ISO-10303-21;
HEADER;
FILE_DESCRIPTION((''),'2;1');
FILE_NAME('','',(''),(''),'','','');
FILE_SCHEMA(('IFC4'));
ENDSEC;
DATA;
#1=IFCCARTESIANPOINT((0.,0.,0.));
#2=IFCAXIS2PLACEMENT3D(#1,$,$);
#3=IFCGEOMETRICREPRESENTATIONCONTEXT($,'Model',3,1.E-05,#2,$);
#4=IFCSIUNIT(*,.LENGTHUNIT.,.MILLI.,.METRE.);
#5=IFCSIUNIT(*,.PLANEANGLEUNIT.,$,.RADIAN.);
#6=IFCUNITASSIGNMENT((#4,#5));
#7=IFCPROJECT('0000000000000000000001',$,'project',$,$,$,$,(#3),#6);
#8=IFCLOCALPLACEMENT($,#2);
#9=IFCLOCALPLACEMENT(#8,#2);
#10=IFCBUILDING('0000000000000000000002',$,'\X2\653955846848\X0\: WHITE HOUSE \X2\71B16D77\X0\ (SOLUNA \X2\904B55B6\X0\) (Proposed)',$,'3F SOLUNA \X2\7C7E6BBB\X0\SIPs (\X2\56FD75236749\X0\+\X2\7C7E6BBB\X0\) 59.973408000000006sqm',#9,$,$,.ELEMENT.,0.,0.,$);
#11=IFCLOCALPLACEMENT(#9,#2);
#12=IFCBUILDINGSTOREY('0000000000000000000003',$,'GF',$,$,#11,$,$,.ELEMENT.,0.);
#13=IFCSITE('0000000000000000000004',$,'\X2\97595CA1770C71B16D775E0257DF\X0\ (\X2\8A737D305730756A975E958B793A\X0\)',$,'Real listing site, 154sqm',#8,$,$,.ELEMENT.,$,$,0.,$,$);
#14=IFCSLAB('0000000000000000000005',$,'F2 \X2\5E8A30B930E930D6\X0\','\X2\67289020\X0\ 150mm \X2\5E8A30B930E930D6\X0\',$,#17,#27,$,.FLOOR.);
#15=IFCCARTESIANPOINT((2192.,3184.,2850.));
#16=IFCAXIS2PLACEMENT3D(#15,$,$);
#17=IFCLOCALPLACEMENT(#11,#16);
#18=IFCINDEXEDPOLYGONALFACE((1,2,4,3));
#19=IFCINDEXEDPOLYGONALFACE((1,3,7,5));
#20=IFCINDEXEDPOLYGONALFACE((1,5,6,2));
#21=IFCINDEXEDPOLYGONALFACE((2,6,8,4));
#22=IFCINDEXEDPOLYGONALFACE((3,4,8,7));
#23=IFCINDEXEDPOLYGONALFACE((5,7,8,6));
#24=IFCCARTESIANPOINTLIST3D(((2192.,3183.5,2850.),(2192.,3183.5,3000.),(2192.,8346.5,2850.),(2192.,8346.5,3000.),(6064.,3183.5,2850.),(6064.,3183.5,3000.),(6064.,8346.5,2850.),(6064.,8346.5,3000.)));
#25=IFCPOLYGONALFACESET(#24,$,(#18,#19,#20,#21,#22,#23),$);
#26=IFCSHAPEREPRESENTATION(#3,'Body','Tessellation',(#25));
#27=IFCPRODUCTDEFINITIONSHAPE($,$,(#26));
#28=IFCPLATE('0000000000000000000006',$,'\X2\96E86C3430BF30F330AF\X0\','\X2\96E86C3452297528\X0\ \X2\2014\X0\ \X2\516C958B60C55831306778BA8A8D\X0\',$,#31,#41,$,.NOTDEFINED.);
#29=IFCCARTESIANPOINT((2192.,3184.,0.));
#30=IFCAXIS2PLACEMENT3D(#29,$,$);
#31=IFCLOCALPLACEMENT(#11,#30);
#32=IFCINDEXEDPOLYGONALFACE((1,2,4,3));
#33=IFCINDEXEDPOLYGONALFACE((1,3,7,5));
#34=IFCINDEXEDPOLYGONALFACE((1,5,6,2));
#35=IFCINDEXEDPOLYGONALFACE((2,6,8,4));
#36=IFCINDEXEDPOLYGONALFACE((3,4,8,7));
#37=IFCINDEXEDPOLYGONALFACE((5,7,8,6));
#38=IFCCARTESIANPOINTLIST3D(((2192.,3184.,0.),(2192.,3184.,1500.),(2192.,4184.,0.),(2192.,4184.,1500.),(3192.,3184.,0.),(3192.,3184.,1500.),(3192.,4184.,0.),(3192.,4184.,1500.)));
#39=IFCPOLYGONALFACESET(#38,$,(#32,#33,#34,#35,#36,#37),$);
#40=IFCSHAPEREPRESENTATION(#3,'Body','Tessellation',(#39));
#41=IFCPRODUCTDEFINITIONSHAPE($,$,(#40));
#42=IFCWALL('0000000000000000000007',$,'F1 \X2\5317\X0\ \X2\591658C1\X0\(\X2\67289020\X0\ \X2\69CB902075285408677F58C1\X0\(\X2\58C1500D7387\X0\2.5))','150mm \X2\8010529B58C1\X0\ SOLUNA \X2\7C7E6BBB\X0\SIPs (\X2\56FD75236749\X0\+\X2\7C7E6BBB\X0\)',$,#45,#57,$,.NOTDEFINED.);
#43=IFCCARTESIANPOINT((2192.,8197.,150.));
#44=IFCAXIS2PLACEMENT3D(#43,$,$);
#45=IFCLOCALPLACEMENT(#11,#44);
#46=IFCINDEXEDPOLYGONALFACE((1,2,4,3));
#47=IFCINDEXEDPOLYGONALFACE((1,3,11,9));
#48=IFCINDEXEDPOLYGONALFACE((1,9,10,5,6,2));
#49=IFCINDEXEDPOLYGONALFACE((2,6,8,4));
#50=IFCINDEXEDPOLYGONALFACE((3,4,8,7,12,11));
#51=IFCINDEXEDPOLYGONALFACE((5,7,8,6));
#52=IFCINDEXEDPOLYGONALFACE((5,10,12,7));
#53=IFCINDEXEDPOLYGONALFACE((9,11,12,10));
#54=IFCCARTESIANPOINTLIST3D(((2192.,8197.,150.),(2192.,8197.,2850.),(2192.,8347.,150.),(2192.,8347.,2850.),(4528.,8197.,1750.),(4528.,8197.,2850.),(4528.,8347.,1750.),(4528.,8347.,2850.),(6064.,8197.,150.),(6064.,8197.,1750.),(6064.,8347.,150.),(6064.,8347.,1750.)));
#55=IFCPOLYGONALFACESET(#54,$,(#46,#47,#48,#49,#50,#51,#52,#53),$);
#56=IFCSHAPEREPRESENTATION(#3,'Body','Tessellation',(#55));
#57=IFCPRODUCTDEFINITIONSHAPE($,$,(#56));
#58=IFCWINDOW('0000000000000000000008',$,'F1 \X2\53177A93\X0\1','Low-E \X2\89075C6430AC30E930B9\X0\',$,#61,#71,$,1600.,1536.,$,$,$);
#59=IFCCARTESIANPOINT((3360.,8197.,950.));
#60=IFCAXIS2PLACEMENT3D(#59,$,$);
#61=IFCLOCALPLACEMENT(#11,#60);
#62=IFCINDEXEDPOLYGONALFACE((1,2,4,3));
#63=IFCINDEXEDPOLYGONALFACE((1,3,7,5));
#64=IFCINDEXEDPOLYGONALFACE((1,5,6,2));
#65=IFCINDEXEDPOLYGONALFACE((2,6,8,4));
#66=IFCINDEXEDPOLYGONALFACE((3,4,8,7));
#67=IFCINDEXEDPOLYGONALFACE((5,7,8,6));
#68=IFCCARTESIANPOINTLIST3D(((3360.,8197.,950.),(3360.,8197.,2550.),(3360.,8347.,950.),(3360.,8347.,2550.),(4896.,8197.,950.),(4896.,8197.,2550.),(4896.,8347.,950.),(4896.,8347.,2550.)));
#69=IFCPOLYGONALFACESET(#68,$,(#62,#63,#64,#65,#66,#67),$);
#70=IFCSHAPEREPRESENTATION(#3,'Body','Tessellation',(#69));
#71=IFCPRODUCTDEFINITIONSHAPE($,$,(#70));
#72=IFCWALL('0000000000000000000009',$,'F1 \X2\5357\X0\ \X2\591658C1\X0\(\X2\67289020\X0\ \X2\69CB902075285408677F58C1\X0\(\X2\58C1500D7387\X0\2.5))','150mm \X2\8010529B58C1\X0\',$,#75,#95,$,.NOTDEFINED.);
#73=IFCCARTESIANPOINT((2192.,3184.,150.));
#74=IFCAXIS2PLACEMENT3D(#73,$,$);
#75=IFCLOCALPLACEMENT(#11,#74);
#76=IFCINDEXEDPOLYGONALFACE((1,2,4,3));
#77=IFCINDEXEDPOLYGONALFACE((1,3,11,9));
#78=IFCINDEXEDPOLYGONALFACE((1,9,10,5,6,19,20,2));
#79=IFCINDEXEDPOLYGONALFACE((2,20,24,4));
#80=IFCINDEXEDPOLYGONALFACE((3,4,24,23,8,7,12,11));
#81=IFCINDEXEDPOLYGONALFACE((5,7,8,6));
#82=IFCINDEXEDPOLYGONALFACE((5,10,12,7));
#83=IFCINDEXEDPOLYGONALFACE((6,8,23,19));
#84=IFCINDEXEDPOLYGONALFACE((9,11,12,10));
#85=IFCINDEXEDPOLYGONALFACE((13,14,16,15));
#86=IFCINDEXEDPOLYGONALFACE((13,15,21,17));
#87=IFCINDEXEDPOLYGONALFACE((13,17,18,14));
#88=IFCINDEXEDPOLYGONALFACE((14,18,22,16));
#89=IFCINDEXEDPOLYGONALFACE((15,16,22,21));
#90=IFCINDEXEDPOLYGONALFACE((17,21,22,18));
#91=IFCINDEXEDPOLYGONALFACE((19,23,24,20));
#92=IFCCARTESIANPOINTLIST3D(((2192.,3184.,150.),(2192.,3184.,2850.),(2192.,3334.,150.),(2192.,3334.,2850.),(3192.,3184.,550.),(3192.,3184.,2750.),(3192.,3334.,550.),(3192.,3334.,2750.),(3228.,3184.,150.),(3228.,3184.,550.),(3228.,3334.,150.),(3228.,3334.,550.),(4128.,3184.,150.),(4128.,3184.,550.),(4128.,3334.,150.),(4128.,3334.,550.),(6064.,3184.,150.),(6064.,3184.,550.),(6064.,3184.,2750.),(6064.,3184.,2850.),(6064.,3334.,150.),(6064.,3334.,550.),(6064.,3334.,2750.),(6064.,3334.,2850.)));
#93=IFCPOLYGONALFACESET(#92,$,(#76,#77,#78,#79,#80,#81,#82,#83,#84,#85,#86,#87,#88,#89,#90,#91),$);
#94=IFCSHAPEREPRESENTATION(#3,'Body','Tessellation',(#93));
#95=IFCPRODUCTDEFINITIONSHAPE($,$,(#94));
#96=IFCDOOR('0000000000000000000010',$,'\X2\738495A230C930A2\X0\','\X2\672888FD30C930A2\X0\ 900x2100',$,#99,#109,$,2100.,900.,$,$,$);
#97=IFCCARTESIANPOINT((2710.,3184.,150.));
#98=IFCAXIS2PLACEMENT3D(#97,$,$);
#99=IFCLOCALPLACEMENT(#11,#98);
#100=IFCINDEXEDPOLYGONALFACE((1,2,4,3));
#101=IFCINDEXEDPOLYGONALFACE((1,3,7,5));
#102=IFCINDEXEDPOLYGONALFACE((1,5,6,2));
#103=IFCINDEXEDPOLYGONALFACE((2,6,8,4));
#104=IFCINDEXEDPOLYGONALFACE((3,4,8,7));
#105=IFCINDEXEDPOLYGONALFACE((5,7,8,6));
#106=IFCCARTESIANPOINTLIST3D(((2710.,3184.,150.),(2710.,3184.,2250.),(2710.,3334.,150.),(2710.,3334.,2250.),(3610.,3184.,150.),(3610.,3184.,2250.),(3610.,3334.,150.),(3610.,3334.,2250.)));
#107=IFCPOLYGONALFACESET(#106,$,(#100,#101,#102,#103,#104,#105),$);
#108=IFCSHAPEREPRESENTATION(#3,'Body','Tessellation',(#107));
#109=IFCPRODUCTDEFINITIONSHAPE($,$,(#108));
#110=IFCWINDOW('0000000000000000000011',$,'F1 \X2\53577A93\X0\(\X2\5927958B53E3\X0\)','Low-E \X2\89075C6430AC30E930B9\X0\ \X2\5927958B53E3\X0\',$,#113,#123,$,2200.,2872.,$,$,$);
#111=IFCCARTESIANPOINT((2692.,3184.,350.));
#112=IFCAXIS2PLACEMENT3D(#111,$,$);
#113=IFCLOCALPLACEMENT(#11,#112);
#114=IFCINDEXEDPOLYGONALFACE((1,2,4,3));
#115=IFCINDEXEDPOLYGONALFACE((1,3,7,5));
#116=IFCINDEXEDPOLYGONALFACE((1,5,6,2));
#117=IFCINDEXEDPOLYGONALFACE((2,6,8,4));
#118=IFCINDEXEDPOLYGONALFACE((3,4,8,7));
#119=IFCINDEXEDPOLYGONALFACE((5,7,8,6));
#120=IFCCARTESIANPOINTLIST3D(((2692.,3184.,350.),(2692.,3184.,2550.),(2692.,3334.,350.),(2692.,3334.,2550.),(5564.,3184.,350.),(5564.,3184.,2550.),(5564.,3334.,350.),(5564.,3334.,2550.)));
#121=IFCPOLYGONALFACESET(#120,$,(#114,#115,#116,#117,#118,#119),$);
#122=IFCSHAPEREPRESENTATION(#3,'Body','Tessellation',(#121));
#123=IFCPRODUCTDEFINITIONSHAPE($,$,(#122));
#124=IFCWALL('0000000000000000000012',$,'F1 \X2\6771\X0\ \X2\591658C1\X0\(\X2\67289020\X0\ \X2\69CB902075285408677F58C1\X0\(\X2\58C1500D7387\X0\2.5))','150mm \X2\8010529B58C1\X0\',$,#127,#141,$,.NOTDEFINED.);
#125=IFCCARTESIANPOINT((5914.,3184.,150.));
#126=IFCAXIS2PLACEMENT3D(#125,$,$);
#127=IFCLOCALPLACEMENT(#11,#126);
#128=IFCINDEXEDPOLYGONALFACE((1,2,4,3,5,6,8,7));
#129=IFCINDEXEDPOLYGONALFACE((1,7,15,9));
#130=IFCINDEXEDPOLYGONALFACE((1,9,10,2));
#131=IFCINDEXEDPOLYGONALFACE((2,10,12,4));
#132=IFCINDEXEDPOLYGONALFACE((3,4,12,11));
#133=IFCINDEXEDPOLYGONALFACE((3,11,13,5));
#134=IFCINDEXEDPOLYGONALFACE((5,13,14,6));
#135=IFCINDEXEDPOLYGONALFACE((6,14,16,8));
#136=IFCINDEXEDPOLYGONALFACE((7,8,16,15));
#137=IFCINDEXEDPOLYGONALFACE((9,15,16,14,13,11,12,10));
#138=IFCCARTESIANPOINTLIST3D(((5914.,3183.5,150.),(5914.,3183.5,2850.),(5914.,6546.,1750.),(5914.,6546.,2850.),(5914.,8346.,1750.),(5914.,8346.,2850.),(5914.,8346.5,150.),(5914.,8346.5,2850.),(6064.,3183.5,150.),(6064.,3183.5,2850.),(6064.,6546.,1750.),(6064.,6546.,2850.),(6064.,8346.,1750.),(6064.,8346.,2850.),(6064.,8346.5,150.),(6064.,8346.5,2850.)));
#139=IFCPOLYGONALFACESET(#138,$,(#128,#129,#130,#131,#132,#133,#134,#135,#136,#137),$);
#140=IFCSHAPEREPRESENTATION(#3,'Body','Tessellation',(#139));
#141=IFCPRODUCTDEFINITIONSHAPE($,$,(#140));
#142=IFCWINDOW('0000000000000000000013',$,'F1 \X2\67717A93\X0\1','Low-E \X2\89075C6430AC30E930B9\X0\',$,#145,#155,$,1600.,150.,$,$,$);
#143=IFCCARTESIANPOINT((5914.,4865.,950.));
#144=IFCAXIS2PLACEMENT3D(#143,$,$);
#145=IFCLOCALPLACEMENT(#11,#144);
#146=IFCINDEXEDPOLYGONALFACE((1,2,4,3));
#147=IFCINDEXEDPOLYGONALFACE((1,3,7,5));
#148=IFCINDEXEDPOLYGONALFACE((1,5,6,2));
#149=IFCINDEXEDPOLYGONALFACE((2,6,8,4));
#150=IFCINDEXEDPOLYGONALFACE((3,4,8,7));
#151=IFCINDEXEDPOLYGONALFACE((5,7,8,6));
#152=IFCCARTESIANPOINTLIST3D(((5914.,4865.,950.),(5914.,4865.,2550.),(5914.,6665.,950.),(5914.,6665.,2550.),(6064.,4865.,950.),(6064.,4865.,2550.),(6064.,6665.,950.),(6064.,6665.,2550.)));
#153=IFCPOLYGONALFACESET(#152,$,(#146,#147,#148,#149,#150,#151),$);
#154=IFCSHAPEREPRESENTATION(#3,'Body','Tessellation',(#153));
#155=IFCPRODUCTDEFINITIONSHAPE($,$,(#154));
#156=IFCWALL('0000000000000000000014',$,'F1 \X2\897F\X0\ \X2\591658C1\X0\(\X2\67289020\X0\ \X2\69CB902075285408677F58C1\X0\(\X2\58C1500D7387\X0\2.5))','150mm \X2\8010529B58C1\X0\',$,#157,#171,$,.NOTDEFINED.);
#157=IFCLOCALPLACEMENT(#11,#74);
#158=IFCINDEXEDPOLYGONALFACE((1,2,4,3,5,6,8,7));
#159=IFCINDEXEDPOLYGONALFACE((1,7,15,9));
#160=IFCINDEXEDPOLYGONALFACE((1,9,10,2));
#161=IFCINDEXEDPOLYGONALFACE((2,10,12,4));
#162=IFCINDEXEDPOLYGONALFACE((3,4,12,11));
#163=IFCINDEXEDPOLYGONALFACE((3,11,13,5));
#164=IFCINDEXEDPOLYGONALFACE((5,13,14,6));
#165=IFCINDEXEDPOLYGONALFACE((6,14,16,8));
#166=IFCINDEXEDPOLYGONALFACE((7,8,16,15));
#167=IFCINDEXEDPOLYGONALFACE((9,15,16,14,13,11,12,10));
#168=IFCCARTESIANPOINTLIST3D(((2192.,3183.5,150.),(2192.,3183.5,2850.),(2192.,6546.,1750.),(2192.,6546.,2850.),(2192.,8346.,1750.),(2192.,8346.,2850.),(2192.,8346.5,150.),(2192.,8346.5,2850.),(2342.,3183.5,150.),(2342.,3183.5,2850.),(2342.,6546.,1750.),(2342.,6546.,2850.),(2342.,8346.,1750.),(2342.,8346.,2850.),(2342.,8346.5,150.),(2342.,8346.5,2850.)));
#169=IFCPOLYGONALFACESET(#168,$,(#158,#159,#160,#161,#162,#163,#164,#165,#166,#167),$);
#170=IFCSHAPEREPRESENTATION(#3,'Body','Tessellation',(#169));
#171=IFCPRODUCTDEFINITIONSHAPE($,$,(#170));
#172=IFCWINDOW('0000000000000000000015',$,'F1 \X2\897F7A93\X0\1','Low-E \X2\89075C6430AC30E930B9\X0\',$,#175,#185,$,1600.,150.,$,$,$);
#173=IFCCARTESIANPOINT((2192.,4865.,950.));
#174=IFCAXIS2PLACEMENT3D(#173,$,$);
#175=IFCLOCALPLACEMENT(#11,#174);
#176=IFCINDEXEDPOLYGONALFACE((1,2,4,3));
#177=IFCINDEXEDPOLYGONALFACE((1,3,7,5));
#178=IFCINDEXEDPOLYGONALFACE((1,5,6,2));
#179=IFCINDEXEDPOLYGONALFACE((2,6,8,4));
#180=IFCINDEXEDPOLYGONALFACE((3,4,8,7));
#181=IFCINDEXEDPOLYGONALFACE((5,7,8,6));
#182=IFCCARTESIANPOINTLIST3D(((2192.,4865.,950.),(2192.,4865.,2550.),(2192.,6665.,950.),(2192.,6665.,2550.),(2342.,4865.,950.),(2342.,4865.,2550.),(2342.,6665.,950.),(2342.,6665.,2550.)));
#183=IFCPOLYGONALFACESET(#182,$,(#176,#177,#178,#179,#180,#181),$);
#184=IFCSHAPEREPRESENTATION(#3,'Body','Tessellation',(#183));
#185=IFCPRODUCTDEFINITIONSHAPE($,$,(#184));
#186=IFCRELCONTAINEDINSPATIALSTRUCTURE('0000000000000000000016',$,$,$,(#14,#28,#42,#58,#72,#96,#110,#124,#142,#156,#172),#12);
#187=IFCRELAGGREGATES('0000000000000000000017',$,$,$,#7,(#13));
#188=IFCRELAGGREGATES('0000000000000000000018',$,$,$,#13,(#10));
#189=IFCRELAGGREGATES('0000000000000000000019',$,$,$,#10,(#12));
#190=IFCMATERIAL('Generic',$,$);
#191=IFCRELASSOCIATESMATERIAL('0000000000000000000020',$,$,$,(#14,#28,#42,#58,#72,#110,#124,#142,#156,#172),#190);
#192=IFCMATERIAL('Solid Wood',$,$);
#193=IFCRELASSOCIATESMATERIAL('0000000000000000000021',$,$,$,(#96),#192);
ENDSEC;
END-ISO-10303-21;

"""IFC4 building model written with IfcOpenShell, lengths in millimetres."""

from ifc_helpers import new_model, si_unit, frame, frame_2d, origin, place, context, project, spatial, rectangle, extrude, material, element, fill, save


model = new_model("IFC4")

# Units and contexts
model_context = context("Model", 3, precision=1e-05, world=origin())
ifc_project = project(units=[si_unit("LENGTHUNIT", "METRE", prefix="MILLI"), si_unit("PLANEANGLEUNIT", "RADIAN")], contexts=[model_context])

# Site, building, storey
site_placement = place(None, origin())
site = spatial("IfcSite", under=ifc_project, at=site_placement, Name="静岡県熱海市域 (詳細地番非開示)", ObjectType="Real listing site, 154sqm", CompositionType="ELEMENT", RefElevation=0.0)
building_placement = place(site_placement, origin())
building = spatial("IfcBuilding", under=site, at=building_placement, Name="改善案: WHITE HOUSE 熱海 (SOLUNA 運営) (Proposed)", ObjectType="3F SOLUNA 籾殻SIPs (国産杉+籾殻) 59.973408000000006sqm", CompositionType="ELEMENT", ElevationOfRefHeight=0.0, ElevationOfTerrain=0.0)
storey_placement = place(building_placement, origin())
storey = spatial("IfcBuildingStorey", under=building, at=storey_placement, Name="GF", CompositionType="ELEMENT", Elevation=0.0)

# Slab
ifc_material_1 = material(Name="Generic")
slab_1_placement = place(storey_placement, frame((2192.0, 3184.0, 2850.0)))
element("IfcSlab", 1, at=slab_1_placement, inside=storey, material=ifc_material_1, Name="F2 床スラブ", Description="木造 150mm 床スラブ", PredefinedType="FLOOR", context=model_context, shape_type="SweptSolid", body=[
    extrude(rectangle(XDim=3872.0, YDim=5163.0, at=frame_2d((1936.0, 2581.0))), frame((2192.0, 3184.0, 2850.0)), (0.0, 0.0, 1.0), 150.0),
])

# Plate
plate_placement = place(storey_placement, frame((2192.0, 3184.0, 0.0)))
element("IfcPlate", 2, at=plate_placement, inside=storey, material=ifc_material_1, Name="雨水タンク", Description="雨水利用 — 公開情報で確認", PredefinedType="NOTDEFINED", context=model_context, shape_type="SweptSolid", body=[
    extrude(rectangle(XDim=1000.0, YDim=1000.0, at=frame_2d((500.0, 500.0))), frame((2192.0, 3184.0, 0.0)), (0.0, 0.0, 1.0), 1500.0),
])

# Wall, opening, window
wall_1_placement = place(storey_placement, frame((2192.0, 8197.0, 150.0)))
wall_1 = element("IfcWall", 3, at=wall_1_placement, inside=storey, material=ifc_material_1, Name="F1 北 外壁(木造 構造用合板壁(壁倍率2.5))", Description="150mm 耐力壁 SOLUNA 籾殻SIPs (国産杉+籾殻)", PredefinedType="NOTDEFINED", context=model_context, shape_type="SweptSolid", body=[
    extrude(rectangle(XDim=3872.0, YDim=150.0, at=frame_2d((1936.0, 75.0))), frame((2192.0, 8197.0, 150.0)), (0.0, 0.0, 1.0), 2700.0),
])
opening_1_placement = place(storey_placement, frame((3360.0, 8197.0, 950.0)))
opening_1 = element("IfcOpeningElement", 4, at=opening_1_placement, cuts=wall_1, PredefinedType="NOTDEFINED", context=model_context, shape_type="SweptSolid", body=[
    extrude(rectangle(XDim=1536.0, YDim=150.0, at=frame_2d((768.0, 75.0))), frame((3360.0, 8197.0, 950.0)), (0.0, 0.0, 1.0), 1600.0),
])
window_1_placement = place(storey_placement, frame((3360.0, 8197.0, 950.0)))
window_1 = element("IfcWindow", 5, at=window_1_placement, inside=storey, material=ifc_material_1, Name="F1 北窓1", Description="Low-E 複層ガラス", OverallHeight=1600.0, OverallWidth=1536.0, context=model_context, shape_type="SweptSolid", body=[
    extrude(rectangle(XDim=1536.0, YDim=150.0, at=frame_2d((768.0, 75.0))), frame((3360.0, 8197.0, 950.0)), (0.0, 0.0, 1.0), 1600.0),
])
fill(opening_1, window_1)

# Wall, openings, door, window
wall_2_placement = place(storey_placement, frame((2192.0, 3184.0, 150.0)))
wall_2 = element("IfcWall", 6, at=wall_2_placement, inside=storey, material=ifc_material_1, Name="F1 南 外壁(木造 構造用合板壁(壁倍率2.5))", Description="150mm 耐力壁", PredefinedType="NOTDEFINED", context=model_context, shape_type="SweptSolid", body=[
    extrude(rectangle(XDim=3872.0, YDim=150.0, at=frame_2d((1936.0, 75.0))), frame((2192.0, 3184.0, 150.0)), (0.0, 0.0, 1.0), 2700.0),
])
opening_2_placement = place(storey_placement, frame((2710.0, 3184.0, 150.0)))
opening_2 = element("IfcOpeningElement", 7, at=opening_2_placement, cuts=wall_2, PredefinedType="NOTDEFINED", context=model_context, shape_type="SweptSolid", body=[
    extrude(rectangle(XDim=900.0, YDim=150.0, at=frame_2d((450.0, 75.0))), frame((2710.0, 3184.0, 150.0)), (0.0, 0.0, 1.0), 2100.0),
])
opening_3_placement = place(storey_placement, frame((2692.0, 3184.0, 350.0)))
opening_3 = element("IfcOpeningElement", 8, at=opening_3_placement, cuts=wall_2, PredefinedType="NOTDEFINED", context=model_context, shape_type="SweptSolid", body=[
    extrude(rectangle(XDim=2872.0, YDim=150.0, at=frame_2d((1436.0, 75.0))), frame((2692.0, 3184.0, 350.0)), (0.0, 0.0, 1.0), 2200.0),
])
ifc_material_2 = material(Name="Solid Wood")
door_placement = place(storey_placement, frame((2710.0, 3184.0, 150.0)))
door = element("IfcDoor", 9, at=door_placement, inside=storey, material=ifc_material_2, Name="玄関ドア", Description="木製ドア 900x2100", OverallHeight=2100.0, OverallWidth=900.0, context=model_context, shape_type="SweptSolid", body=[
    extrude(rectangle(XDim=900.0, YDim=150.0, at=frame_2d((450.0, 75.0))), frame((2710.0, 3184.0, 150.0)), (0.0, 0.0, 1.0), 2100.0),
])
fill(opening_2, door)
window_2_placement = place(storey_placement, frame((2692.0, 3184.0, 350.0)))
window_2 = element("IfcWindow", 10, at=window_2_placement, inside=storey, material=ifc_material_1, Name="F1 南窓(大開口)", Description="Low-E 複層ガラス 大開口", OverallHeight=2200.0, OverallWidth=2872.0, context=model_context, shape_type="SweptSolid", body=[
    extrude(rectangle(XDim=2872.0, YDim=150.0, at=frame_2d((1436.0, 75.0))), frame((2692.0, 3184.0, 350.0)), (0.0, 0.0, 1.0), 2200.0),
])
fill(opening_3, window_2)

# Walls, openings, windows
wall_3_placement = place(storey_placement, frame((5914.0, 3184.0, 150.0)))
wall_3 = element("IfcWall", 11, at=wall_3_placement, inside=storey, material=ifc_material_1, Name="F1 東 外壁(木造 構造用合板壁(壁倍率2.5))", Description="150mm 耐力壁", PredefinedType="NOTDEFINED", context=model_context, shape_type="SweptSolid", body=[
    extrude(rectangle(XDim=150.0, YDim=5163.0, at=frame_2d((75.0, 2581.0))), frame((5914.0, 3184.0, 150.0)), (0.0, 0.0, 1.0), 2700.0),
])
opening_4_placement = place(storey_placement, frame((5914.0, 4865.0, 950.0)))
opening_4 = element("IfcOpeningElement", 12, at=opening_4_placement, cuts=wall_3, PredefinedType="NOTDEFINED", context=model_context, shape_type="SweptSolid", body=[
    extrude(rectangle(XDim=150.0, YDim=1800.0, at=frame_2d((75.0, 900.0))), frame((5914.0, 4865.0, 950.0)), (0.0, 0.0, 1.0), 1600.0),
])
window_3_placement = place(storey_placement, frame((5914.0, 4865.0, 950.0)))
window_3 = element("IfcWindow", 13, at=window_3_placement, inside=storey, material=ifc_material_1, Name="F1 東窓1", Description="Low-E 複層ガラス", OverallHeight=1600.0, OverallWidth=150.0, context=model_context, shape_type="SweptSolid", body=[
    extrude(rectangle(XDim=150.0, YDim=1800.0, at=frame_2d((75.0, 900.0))), frame((5914.0, 4865.0, 950.0)), (0.0, 0.0, 1.0), 1600.0),
])
fill(opening_4, window_3)
wall_4_placement = place(storey_placement, frame((2192.0, 3184.0, 150.0)))
wall_4 = element("IfcWall", 14, at=wall_4_placement, inside=storey, material=ifc_material_1, Name="F1 西 外壁(木造 構造用合板壁(壁倍率2.5))", Description="150mm 耐力壁", PredefinedType="NOTDEFINED", context=model_context, shape_type="SweptSolid", body=[
    extrude(rectangle(XDim=150.0, YDim=5163.0, at=frame_2d((75.0, 2581.0))), frame((2192.0, 3184.0, 150.0)), (0.0, 0.0, 1.0), 2700.0),
])
opening_5_placement = place(storey_placement, frame((2192.0, 4865.0, 950.0)))
opening_5 = element("IfcOpeningElement", 15, at=opening_5_placement, cuts=wall_4, PredefinedType="NOTDEFINED", context=model_context, shape_type="SweptSolid", body=[
    extrude(rectangle(XDim=150.0, YDim=1800.0, at=frame_2d((75.0, 900.0))), frame((2192.0, 4865.0, 950.0)), (0.0, 0.0, 1.0), 1600.0),
])
window_4_placement = place(storey_placement, frame((2192.0, 4865.0, 950.0)))
window_4 = element("IfcWindow", 16, at=window_4_placement, inside=storey, material=ifc_material_1, Name="F1 西窓1", Description="Low-E 複層ガラス", OverallHeight=1600.0, OverallWidth=150.0, context=model_context, shape_type="SweptSolid", body=[
    extrude(rectangle(XDim=150.0, YDim=1800.0, at=frame_2d((75.0, 900.0))), frame((2192.0, 4865.0, 950.0)), (0.0, 0.0, 1.0), 1600.0),
])
fill(opening_5, window_4)

save(model, "model.ifc")
